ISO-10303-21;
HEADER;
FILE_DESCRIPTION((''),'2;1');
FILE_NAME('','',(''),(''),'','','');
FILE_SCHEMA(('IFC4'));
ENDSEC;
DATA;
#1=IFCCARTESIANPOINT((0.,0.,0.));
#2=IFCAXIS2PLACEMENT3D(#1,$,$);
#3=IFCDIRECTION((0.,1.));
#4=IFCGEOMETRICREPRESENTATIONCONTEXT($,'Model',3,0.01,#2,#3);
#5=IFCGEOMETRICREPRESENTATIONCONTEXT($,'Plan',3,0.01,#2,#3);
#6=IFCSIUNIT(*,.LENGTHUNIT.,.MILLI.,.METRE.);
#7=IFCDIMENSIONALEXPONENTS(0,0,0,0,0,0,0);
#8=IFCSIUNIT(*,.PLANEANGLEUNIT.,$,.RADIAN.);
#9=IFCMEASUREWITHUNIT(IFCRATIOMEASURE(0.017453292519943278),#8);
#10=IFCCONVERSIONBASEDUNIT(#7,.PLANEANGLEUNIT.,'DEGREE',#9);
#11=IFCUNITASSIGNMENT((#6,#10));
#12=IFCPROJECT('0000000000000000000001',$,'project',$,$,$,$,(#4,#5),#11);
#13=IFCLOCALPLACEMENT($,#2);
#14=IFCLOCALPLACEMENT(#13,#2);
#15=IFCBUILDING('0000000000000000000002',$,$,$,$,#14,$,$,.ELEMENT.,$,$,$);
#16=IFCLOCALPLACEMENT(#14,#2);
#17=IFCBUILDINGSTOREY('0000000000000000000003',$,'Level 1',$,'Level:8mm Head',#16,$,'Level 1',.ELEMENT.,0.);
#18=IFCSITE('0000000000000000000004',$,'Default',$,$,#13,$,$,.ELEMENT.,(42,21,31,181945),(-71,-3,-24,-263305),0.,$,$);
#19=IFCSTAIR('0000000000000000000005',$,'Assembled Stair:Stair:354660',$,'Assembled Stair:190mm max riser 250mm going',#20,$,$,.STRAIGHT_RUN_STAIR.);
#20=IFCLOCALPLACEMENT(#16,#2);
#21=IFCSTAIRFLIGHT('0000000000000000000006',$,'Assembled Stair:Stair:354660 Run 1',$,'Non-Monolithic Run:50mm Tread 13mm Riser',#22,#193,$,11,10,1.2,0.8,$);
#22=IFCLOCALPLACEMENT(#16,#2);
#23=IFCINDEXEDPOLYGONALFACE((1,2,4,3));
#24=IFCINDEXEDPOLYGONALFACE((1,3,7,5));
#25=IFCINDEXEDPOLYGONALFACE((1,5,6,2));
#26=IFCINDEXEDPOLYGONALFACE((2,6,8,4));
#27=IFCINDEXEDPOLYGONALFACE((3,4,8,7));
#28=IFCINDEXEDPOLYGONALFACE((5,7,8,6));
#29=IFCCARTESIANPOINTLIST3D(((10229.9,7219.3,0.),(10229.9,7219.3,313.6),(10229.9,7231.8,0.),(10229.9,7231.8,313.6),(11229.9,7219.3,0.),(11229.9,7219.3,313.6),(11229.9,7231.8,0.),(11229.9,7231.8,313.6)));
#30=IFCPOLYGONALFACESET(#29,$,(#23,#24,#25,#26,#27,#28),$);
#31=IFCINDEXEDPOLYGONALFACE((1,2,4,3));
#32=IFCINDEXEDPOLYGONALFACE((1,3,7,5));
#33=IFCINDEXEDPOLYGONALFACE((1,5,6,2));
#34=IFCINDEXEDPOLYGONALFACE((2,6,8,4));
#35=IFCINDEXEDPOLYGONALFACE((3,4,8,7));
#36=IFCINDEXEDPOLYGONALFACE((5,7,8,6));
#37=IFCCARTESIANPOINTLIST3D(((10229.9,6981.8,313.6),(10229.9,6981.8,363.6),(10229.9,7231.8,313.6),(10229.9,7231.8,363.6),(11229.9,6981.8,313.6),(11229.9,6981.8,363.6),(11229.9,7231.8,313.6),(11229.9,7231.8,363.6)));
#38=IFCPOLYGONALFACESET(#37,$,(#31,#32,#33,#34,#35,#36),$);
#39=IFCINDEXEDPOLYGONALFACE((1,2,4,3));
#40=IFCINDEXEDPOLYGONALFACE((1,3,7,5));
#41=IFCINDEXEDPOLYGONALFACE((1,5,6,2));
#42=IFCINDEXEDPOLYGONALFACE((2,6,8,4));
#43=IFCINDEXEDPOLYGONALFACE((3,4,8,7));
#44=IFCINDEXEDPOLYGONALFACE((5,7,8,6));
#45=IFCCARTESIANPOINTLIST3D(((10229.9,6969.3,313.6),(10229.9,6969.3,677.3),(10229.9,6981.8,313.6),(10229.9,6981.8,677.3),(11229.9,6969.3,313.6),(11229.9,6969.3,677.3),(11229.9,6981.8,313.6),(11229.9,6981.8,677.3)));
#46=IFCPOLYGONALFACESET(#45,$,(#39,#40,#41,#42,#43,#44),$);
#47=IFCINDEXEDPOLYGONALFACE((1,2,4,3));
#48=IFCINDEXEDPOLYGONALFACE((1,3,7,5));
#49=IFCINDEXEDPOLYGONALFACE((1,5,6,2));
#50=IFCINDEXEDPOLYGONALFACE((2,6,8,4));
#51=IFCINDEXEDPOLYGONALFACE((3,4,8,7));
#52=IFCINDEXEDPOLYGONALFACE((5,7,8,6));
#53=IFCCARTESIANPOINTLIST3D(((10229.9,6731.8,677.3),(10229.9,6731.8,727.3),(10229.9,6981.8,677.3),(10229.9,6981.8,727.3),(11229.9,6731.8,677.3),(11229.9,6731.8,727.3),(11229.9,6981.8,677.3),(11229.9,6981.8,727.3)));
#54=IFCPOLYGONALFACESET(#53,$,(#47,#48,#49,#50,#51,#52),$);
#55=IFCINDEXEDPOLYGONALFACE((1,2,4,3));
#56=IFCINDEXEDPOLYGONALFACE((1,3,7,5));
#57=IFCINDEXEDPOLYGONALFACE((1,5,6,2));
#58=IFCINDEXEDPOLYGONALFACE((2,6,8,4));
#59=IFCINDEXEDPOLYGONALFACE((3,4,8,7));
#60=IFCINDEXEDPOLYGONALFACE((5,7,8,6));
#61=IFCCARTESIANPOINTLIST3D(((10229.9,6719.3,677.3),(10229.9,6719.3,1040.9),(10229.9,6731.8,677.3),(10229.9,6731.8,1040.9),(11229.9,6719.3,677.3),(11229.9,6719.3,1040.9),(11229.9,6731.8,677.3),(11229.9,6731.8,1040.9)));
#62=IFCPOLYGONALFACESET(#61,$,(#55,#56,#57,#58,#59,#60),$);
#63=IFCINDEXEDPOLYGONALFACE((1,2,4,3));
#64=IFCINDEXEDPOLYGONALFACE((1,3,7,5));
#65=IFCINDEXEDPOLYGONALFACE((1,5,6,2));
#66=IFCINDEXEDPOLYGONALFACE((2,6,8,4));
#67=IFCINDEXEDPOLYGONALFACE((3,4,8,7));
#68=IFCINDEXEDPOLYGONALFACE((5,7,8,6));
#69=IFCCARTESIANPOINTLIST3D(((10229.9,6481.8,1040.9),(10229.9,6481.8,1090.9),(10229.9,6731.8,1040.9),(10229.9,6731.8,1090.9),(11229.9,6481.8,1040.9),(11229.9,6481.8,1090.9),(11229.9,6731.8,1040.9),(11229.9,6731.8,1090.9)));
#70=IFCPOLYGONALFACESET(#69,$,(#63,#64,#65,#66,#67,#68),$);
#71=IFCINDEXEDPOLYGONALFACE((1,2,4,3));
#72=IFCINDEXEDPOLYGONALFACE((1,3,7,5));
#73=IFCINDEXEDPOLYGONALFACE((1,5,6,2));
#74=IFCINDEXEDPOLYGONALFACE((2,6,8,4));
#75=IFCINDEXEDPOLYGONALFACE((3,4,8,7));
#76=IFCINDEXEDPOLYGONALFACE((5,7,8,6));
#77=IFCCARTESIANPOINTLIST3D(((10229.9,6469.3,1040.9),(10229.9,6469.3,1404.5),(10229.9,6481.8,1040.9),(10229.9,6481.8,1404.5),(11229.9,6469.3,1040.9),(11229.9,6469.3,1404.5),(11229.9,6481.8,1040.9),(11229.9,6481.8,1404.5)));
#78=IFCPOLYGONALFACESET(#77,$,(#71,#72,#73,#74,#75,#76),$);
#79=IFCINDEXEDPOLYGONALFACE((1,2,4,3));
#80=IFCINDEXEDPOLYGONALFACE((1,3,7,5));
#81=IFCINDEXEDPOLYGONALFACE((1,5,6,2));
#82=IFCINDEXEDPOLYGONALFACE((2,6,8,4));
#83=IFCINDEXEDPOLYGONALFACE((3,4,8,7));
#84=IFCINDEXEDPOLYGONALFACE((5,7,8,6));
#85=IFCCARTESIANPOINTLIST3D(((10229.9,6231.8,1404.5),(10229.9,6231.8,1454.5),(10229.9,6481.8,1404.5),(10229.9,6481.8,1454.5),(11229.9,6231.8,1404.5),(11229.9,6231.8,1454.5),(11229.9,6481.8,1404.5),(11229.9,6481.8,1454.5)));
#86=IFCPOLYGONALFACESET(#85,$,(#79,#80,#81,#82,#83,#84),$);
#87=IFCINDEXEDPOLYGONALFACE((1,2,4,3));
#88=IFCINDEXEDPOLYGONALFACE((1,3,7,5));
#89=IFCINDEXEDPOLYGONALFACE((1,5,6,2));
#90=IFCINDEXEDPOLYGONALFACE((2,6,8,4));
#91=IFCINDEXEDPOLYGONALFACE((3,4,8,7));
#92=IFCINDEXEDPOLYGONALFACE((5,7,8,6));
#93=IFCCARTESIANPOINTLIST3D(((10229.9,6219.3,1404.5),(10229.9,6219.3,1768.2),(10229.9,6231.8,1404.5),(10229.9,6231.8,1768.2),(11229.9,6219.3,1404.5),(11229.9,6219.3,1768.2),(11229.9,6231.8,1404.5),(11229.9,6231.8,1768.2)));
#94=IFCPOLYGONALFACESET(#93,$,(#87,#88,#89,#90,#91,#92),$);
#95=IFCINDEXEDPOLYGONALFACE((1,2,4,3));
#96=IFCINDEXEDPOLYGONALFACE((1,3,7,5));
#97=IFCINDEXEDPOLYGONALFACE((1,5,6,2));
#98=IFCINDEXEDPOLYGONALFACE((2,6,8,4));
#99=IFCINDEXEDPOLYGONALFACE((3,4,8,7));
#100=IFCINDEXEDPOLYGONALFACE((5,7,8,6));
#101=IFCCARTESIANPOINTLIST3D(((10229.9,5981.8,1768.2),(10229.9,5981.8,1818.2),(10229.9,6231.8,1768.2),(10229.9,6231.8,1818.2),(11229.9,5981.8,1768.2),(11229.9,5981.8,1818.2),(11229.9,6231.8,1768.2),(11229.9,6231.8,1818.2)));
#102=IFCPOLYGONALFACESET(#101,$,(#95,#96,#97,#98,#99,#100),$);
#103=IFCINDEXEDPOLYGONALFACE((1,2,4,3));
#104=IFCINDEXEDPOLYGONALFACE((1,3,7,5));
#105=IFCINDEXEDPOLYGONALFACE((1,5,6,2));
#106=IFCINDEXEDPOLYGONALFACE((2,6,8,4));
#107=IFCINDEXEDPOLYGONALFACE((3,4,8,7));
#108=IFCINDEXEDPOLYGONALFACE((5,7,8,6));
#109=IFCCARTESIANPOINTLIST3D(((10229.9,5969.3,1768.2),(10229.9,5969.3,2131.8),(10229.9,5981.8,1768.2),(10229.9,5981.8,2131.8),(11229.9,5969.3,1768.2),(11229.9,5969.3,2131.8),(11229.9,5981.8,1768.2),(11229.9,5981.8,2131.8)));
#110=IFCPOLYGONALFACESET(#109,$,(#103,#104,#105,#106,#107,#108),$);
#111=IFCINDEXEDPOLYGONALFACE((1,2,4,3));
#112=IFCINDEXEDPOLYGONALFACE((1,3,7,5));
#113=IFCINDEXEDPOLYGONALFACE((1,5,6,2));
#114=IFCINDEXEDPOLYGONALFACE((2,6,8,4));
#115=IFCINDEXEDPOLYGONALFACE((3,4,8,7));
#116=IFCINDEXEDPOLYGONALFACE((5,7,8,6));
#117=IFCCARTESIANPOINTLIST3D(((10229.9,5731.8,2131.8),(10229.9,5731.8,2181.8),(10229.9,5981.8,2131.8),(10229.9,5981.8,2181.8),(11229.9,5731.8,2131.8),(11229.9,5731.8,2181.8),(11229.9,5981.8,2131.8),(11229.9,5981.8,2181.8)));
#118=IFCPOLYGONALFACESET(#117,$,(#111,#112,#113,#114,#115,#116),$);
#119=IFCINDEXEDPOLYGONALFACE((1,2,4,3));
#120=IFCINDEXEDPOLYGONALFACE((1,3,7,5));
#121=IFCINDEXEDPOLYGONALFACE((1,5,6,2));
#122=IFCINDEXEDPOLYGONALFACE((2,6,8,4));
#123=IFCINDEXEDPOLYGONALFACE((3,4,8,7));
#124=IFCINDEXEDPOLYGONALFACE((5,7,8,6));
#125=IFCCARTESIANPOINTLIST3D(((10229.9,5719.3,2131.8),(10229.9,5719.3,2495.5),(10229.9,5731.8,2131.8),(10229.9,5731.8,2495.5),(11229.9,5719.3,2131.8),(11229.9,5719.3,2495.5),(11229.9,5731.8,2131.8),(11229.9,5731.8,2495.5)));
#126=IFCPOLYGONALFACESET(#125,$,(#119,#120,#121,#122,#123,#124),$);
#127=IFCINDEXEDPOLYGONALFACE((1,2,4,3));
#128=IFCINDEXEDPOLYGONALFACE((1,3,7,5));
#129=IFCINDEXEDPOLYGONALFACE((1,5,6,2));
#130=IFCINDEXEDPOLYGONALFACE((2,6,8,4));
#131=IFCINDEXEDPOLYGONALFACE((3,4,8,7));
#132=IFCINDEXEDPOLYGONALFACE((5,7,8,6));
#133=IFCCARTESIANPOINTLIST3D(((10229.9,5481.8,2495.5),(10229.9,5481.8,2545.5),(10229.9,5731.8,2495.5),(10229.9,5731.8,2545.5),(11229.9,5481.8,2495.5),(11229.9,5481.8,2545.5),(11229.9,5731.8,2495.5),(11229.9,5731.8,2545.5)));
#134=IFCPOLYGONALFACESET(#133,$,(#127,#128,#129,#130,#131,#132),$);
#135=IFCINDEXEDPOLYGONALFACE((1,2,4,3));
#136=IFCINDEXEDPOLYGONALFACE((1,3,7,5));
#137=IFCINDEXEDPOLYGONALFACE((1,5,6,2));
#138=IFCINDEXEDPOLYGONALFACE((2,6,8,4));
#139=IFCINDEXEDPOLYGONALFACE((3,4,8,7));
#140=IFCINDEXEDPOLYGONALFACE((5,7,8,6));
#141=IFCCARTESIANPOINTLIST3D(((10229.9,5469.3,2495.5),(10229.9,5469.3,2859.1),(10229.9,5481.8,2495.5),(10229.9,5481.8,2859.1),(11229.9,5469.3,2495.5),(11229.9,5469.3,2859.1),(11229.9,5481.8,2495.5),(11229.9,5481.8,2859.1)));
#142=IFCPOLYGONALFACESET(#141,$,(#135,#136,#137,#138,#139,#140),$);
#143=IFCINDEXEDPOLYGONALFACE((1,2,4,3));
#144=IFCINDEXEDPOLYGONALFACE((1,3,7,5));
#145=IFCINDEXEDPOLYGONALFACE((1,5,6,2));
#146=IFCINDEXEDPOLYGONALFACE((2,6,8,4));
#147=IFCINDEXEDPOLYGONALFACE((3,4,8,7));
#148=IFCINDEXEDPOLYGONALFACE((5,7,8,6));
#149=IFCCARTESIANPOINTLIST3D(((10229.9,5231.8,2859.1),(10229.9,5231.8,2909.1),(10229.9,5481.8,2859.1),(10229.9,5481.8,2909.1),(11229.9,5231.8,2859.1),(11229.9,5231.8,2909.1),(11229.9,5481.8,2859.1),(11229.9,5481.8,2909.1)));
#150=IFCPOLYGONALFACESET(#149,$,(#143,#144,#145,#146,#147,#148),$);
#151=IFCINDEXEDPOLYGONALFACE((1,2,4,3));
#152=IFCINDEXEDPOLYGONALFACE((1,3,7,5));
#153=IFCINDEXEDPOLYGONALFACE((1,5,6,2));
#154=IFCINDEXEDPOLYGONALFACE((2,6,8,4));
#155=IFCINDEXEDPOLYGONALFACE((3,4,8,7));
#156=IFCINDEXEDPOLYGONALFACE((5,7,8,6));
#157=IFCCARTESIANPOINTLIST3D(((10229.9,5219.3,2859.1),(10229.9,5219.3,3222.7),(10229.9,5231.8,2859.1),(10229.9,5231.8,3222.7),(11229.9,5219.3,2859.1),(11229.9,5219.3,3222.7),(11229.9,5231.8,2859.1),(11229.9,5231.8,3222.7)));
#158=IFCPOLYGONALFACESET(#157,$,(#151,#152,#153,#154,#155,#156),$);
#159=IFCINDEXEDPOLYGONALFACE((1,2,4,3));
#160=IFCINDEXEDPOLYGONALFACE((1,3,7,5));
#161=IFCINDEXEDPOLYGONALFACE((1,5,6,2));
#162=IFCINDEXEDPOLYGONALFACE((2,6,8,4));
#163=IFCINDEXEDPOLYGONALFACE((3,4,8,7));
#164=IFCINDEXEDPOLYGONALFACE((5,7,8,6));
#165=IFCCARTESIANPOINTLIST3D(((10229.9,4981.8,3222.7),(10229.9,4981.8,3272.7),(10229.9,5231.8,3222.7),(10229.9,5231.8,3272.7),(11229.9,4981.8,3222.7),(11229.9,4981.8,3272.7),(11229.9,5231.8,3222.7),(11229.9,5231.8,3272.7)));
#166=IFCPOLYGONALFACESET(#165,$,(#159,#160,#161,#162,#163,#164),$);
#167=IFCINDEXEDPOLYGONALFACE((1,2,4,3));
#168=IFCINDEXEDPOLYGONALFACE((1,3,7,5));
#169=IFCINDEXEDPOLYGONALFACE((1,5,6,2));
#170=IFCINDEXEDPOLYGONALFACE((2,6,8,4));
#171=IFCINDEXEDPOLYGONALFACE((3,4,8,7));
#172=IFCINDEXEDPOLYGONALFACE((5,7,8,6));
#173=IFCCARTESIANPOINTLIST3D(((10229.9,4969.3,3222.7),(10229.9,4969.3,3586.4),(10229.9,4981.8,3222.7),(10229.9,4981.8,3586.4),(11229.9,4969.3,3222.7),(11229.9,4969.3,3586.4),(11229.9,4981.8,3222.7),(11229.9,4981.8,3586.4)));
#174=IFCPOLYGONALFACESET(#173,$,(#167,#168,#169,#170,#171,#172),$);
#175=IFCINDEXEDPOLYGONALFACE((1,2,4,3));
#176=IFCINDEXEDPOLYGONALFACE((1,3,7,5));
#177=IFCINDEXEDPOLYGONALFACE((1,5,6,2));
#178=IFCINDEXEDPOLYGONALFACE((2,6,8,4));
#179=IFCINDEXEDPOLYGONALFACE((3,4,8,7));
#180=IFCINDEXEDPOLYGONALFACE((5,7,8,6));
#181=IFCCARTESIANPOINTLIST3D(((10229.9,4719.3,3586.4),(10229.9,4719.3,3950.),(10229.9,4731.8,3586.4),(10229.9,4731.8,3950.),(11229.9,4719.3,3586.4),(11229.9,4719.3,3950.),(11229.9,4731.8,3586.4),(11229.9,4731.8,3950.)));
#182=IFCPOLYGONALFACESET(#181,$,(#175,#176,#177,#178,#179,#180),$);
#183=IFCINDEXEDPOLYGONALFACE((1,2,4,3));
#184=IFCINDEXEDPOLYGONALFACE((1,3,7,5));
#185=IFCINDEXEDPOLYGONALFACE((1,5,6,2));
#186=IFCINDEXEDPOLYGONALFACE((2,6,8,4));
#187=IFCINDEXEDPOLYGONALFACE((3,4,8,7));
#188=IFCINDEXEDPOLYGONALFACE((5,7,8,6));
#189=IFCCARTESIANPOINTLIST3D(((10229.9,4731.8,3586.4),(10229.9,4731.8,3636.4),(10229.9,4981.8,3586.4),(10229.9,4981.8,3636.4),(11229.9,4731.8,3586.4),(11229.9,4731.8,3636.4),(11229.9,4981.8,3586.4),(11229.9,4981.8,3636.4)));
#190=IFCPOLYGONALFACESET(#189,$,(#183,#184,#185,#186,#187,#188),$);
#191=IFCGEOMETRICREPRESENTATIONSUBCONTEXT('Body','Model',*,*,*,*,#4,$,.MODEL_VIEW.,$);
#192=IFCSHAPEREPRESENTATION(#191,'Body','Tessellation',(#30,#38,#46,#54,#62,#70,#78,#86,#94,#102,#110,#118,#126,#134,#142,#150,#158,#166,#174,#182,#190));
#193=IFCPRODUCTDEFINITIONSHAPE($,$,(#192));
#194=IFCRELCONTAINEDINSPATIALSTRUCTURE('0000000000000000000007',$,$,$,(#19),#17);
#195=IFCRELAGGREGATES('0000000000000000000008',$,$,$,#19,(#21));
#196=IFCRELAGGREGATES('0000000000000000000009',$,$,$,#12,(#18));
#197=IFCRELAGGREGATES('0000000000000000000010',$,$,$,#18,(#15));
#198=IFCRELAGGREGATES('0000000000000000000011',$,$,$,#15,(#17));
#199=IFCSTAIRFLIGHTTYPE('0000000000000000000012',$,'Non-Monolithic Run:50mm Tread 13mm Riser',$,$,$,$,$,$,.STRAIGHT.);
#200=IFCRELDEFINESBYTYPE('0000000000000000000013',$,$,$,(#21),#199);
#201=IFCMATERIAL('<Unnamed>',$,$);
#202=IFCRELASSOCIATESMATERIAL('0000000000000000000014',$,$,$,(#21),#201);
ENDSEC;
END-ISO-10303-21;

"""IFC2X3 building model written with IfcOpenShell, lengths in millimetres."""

from ifc_helpers import new_model, entity, si_unit, converted_unit, direction, frame, frame_2d, origin, origin_2d_with_axis, place, context, subcontext, project, spatial, rectangle, extrude, material, type_object, element, aggregate, save


model = new_model("IFC2X3")

# Units and contexts
model_context = context("Model", 3, precision=0.01, world=origin(), true_north=direction((0.0, 1.0)))
plan_context = context("Plan", 3, precision=0.01, world=origin(), true_north=direction((0.0, 1.0)))
body_context = subcontext(model_context, "Body", "Model", "MODEL_VIEW")
ifc_project = project(units=[si_unit("LENGTHUNIT", "METRE", prefix="MILLI"), converted_unit("PLANEANGLEUNIT", "DEGREE", entity("IfcRatioMeasure", 0.017453292519943278), si_unit("PLANEANGLEUNIT", "RADIAN"), dimensions=[0, 0, 0, 0, 0, 0, 0])], contexts=[model_context, plan_context])

# Site, building, storey
site_placement = place(None, origin())
site = spatial("IfcSite", under=ifc_project, at=site_placement, Name="Default", CompositionType="ELEMENT", RefLatitude=(42, 21, 31, 181945), RefLongitude=(-71, -3, -24, -263305), RefElevation=0.0)
building_placement = place(site_placement, origin())
building = spatial("IfcBuilding", under=site, at=building_placement, CompositionType="ELEMENT")
storey_placement = place(building_placement, origin())
storey = spatial("IfcBuildingStorey", under=building, at=storey_placement, Name="Level 1", ObjectType="Level:8mm Head", LongName="Level 1", CompositionType="ELEMENT", Elevation=0.0)

# Stair
stair_placement = place(storey_placement, origin())
stair = element("IfcStair", 1, at=stair_placement, inside=storey, Name="Assembled Stair:Stair:354660", ObjectType="Assembled Stair:190mm max riser 250mm going", ShapeType="STRAIGHT_RUN_STAIR")
ifc_material_1 = material(Name="<Unnamed>")

# Stair flight
stair_flight_type = type_object("IfcStairFlightType", Name="Non-Monolithic Run:50mm Tread 13mm Riser", PredefinedType="STRAIGHT")
stair_flight_placement = place(stair_placement, frame((10229.9, 4719.3, 0.0)))
stair_flight = element("IfcStairFlight", 2, at=stair_flight_placement, type_object=stair_flight_type, material=ifc_material_1, Name="Assembled Stair:Stair:354660 Run 1", ObjectType="Non-Monolithic Run:50mm Tread 13mm Riser", NumberOfRiser=11, NumberOfTreads=10, RiserHeight=1.2, TreadLength=0.8, context=body_context, shape_type="SweptSolid", body=[
    extrude(rectangle(XDim=1000.0, YDim=12.5, at=frame_2d((0.0, 0.0), x_axis=(1.0, 0.0))), frame((500.0, 2506.2, 0.0)), (0.0, 0.0, 1.0), 313.6),
    extrude(rectangle(XDim=250.0, YDim=1000.0, at=origin_2d_with_axis()), frame((500.0, 2387.5, 313.6), z_axis=(0.0, 0.0, 1.0), x_axis=(0.0, 1.0, 0.0)), (0.0, 0.0, 1.0), 50.0),
    extrude(rectangle(XDim=1000.0, YDim=12.5, at=frame_2d((0.0, 0.0), x_axis=(1.0, 0.0))), frame((500.0, 2256.2, 313.6)), (0.0, 0.0, 1.0), 363.6),
    extrude(rectangle(XDim=250.0, YDim=1000.0, at=frame_2d((0.0, 0.0), x_axis=(1.0, 0.0))), frame((500.0, 2137.5, 677.3), z_axis=(0.0, 0.0, 1.0), x_axis=(0.0, 1.0, 0.0)), (0.0, 0.0, 1.0), 50.0),
    extrude(rectangle(XDim=1000.0, YDim=12.5, at=frame_2d((0.0, 0.0), x_axis=(1.0, 0.0))), frame((500.0, 2006.2, 677.3)), (0.0, 0.0, 1.0), 363.6),
    extrude(rectangle(XDim=250.0, YDim=1000.0, at=frame_2d((0.0, 0.0), x_axis=(1.0, 0.0))), frame((500.0, 1887.5, 1040.9), z_axis=(0.0, 0.0, 1.0), x_axis=(0.0, 1.0, 0.0)), (0.0, 0.0, 1.0), 50.0),
    extrude(rectangle(XDim=1000.0, YDim=12.5, at=frame_2d((0.0, 0.0), x_axis=(1.0, 0.0))), frame((500.0, 1756.2, 1040.9)), (0.0, 0.0, 1.0), 363.6),
    extrude(rectangle(XDim=250.0, YDim=1000.0, at=frame_2d((0.0, 0.0), x_axis=(1.0, 0.0))), frame((500.0, 1637.5, 1404.5), z_axis=(0.0, 0.0, 1.0), x_axis=(0.0, 1.0, 0.0)), (0.0, 0.0, 1.0), 50.0),
    extrude(rectangle(XDim=1000.0, YDim=12.5, at=frame_2d((0.0, 0.0), x_axis=(1.0, 0.0))), frame((500.0, 1506.2, 1404.5)), (0.0, 0.0, 1.0), 363.6),
    extrude(rectangle(XDim=250.0, YDim=1000.0, at=frame_2d((0.0, 0.0), x_axis=(1.0, 0.0))), frame((500.0, 1387.5, 1768.2), z_axis=(0.0, 0.0, 1.0), x_axis=(0.0, 1.0, 0.0)), (0.0, 0.0, 1.0), 50.0),
    extrude(rectangle(XDim=1000.0, YDim=12.5, at=frame_2d((0.0, 0.0), x_axis=(1.0, 0.0))), frame((500.0, 1256.3, 1768.2)), (0.0, 0.0, 1.0), 363.6),
    extrude(rectangle(XDim=250.0, YDim=1000.0, at=frame_2d((0.0, 0.0), x_axis=(1.0, 0.0))), frame((500.0, 1137.5, 2131.8), z_axis=(0.0, 0.0, 1.0), x_axis=(0.0, 1.0, 0.0)), (0.0, 0.0, 1.0), 50.0),
    extrude(rectangle(XDim=1000.0, YDim=12.5, at=frame_2d((0.0, 0.0), x_axis=(1.0, 0.0))), frame((500.0, 1006.3, 2131.8)), (0.0, 0.0, 1.0), 363.6),
    extrude(rectangle(XDim=250.0, YDim=1000.0, at=frame_2d((0.0, 0.0), x_axis=(1.0, 0.0))), frame((500.0, 887.5, 2495.5), z_axis=(0.0, 0.0, 1.0), x_axis=(0.0, 1.0, 0.0)), (0.0, 0.0, 1.0), 50.0),
    extrude(rectangle(XDim=1000.0, YDim=12.5, at=frame_2d((0.0, 0.0), x_axis=(1.0, 0.0))), frame((500.0, 756.2, 2495.5)), (0.0, 0.0, 1.0), 363.6),
    extrude(rectangle(XDim=250.0, YDim=1000.0, at=frame_2d((0.0, 0.0), x_axis=(1.0, 0.0))), frame((500.0, 637.5, 2859.1), z_axis=(0.0, 0.0, 1.0), x_axis=(0.0, 1.0, 0.0)), (0.0, 0.0, 1.0), 50.0),
    extrude(rectangle(XDim=1000.0, YDim=12.5, at=frame_2d((0.0, 0.0), x_axis=(1.0, 0.0))), frame((500.0, 506.2, 2859.1)), (0.0, 0.0, 1.0), 363.6),
    extrude(rectangle(XDim=250.0, YDim=1000.0, at=frame_2d((0.0, 0.0), x_axis=(1.0, 0.0))), frame((500.0, 387.5, 3222.7), z_axis=(0.0, 0.0, 1.0), x_axis=(0.0, 1.0, 0.0)), (0.0, 0.0, 1.0), 50.0),
    extrude(rectangle(XDim=1000.0, YDim=12.5, at=frame_2d((0.0, 0.0), x_axis=(1.0, 0.0))), frame((500.0, 256.2, 3222.7)), (0.0, 0.0, 1.0), 363.6),
    extrude(rectangle(XDim=1000.0, YDim=12.5, at=frame_2d((0.0, 0.0), x_axis=(1.0, 0.0))), frame((500.0, 6.2, 3586.4)), (0.0, 0.0, 1.0), 363.6),
    extrude(rectangle(XDim=250.0, YDim=1000.0, at=origin_2d_with_axis()), frame((500.0, 137.5, 3586.4), z_axis=(0.0, 0.0, 1.0), x_axis=(0.0, 1.0, 0.0)), (0.0, 0.0, 1.0), 50.0),
])

aggregate(stair, [stair_flight])

save(model, "model.ifc")
